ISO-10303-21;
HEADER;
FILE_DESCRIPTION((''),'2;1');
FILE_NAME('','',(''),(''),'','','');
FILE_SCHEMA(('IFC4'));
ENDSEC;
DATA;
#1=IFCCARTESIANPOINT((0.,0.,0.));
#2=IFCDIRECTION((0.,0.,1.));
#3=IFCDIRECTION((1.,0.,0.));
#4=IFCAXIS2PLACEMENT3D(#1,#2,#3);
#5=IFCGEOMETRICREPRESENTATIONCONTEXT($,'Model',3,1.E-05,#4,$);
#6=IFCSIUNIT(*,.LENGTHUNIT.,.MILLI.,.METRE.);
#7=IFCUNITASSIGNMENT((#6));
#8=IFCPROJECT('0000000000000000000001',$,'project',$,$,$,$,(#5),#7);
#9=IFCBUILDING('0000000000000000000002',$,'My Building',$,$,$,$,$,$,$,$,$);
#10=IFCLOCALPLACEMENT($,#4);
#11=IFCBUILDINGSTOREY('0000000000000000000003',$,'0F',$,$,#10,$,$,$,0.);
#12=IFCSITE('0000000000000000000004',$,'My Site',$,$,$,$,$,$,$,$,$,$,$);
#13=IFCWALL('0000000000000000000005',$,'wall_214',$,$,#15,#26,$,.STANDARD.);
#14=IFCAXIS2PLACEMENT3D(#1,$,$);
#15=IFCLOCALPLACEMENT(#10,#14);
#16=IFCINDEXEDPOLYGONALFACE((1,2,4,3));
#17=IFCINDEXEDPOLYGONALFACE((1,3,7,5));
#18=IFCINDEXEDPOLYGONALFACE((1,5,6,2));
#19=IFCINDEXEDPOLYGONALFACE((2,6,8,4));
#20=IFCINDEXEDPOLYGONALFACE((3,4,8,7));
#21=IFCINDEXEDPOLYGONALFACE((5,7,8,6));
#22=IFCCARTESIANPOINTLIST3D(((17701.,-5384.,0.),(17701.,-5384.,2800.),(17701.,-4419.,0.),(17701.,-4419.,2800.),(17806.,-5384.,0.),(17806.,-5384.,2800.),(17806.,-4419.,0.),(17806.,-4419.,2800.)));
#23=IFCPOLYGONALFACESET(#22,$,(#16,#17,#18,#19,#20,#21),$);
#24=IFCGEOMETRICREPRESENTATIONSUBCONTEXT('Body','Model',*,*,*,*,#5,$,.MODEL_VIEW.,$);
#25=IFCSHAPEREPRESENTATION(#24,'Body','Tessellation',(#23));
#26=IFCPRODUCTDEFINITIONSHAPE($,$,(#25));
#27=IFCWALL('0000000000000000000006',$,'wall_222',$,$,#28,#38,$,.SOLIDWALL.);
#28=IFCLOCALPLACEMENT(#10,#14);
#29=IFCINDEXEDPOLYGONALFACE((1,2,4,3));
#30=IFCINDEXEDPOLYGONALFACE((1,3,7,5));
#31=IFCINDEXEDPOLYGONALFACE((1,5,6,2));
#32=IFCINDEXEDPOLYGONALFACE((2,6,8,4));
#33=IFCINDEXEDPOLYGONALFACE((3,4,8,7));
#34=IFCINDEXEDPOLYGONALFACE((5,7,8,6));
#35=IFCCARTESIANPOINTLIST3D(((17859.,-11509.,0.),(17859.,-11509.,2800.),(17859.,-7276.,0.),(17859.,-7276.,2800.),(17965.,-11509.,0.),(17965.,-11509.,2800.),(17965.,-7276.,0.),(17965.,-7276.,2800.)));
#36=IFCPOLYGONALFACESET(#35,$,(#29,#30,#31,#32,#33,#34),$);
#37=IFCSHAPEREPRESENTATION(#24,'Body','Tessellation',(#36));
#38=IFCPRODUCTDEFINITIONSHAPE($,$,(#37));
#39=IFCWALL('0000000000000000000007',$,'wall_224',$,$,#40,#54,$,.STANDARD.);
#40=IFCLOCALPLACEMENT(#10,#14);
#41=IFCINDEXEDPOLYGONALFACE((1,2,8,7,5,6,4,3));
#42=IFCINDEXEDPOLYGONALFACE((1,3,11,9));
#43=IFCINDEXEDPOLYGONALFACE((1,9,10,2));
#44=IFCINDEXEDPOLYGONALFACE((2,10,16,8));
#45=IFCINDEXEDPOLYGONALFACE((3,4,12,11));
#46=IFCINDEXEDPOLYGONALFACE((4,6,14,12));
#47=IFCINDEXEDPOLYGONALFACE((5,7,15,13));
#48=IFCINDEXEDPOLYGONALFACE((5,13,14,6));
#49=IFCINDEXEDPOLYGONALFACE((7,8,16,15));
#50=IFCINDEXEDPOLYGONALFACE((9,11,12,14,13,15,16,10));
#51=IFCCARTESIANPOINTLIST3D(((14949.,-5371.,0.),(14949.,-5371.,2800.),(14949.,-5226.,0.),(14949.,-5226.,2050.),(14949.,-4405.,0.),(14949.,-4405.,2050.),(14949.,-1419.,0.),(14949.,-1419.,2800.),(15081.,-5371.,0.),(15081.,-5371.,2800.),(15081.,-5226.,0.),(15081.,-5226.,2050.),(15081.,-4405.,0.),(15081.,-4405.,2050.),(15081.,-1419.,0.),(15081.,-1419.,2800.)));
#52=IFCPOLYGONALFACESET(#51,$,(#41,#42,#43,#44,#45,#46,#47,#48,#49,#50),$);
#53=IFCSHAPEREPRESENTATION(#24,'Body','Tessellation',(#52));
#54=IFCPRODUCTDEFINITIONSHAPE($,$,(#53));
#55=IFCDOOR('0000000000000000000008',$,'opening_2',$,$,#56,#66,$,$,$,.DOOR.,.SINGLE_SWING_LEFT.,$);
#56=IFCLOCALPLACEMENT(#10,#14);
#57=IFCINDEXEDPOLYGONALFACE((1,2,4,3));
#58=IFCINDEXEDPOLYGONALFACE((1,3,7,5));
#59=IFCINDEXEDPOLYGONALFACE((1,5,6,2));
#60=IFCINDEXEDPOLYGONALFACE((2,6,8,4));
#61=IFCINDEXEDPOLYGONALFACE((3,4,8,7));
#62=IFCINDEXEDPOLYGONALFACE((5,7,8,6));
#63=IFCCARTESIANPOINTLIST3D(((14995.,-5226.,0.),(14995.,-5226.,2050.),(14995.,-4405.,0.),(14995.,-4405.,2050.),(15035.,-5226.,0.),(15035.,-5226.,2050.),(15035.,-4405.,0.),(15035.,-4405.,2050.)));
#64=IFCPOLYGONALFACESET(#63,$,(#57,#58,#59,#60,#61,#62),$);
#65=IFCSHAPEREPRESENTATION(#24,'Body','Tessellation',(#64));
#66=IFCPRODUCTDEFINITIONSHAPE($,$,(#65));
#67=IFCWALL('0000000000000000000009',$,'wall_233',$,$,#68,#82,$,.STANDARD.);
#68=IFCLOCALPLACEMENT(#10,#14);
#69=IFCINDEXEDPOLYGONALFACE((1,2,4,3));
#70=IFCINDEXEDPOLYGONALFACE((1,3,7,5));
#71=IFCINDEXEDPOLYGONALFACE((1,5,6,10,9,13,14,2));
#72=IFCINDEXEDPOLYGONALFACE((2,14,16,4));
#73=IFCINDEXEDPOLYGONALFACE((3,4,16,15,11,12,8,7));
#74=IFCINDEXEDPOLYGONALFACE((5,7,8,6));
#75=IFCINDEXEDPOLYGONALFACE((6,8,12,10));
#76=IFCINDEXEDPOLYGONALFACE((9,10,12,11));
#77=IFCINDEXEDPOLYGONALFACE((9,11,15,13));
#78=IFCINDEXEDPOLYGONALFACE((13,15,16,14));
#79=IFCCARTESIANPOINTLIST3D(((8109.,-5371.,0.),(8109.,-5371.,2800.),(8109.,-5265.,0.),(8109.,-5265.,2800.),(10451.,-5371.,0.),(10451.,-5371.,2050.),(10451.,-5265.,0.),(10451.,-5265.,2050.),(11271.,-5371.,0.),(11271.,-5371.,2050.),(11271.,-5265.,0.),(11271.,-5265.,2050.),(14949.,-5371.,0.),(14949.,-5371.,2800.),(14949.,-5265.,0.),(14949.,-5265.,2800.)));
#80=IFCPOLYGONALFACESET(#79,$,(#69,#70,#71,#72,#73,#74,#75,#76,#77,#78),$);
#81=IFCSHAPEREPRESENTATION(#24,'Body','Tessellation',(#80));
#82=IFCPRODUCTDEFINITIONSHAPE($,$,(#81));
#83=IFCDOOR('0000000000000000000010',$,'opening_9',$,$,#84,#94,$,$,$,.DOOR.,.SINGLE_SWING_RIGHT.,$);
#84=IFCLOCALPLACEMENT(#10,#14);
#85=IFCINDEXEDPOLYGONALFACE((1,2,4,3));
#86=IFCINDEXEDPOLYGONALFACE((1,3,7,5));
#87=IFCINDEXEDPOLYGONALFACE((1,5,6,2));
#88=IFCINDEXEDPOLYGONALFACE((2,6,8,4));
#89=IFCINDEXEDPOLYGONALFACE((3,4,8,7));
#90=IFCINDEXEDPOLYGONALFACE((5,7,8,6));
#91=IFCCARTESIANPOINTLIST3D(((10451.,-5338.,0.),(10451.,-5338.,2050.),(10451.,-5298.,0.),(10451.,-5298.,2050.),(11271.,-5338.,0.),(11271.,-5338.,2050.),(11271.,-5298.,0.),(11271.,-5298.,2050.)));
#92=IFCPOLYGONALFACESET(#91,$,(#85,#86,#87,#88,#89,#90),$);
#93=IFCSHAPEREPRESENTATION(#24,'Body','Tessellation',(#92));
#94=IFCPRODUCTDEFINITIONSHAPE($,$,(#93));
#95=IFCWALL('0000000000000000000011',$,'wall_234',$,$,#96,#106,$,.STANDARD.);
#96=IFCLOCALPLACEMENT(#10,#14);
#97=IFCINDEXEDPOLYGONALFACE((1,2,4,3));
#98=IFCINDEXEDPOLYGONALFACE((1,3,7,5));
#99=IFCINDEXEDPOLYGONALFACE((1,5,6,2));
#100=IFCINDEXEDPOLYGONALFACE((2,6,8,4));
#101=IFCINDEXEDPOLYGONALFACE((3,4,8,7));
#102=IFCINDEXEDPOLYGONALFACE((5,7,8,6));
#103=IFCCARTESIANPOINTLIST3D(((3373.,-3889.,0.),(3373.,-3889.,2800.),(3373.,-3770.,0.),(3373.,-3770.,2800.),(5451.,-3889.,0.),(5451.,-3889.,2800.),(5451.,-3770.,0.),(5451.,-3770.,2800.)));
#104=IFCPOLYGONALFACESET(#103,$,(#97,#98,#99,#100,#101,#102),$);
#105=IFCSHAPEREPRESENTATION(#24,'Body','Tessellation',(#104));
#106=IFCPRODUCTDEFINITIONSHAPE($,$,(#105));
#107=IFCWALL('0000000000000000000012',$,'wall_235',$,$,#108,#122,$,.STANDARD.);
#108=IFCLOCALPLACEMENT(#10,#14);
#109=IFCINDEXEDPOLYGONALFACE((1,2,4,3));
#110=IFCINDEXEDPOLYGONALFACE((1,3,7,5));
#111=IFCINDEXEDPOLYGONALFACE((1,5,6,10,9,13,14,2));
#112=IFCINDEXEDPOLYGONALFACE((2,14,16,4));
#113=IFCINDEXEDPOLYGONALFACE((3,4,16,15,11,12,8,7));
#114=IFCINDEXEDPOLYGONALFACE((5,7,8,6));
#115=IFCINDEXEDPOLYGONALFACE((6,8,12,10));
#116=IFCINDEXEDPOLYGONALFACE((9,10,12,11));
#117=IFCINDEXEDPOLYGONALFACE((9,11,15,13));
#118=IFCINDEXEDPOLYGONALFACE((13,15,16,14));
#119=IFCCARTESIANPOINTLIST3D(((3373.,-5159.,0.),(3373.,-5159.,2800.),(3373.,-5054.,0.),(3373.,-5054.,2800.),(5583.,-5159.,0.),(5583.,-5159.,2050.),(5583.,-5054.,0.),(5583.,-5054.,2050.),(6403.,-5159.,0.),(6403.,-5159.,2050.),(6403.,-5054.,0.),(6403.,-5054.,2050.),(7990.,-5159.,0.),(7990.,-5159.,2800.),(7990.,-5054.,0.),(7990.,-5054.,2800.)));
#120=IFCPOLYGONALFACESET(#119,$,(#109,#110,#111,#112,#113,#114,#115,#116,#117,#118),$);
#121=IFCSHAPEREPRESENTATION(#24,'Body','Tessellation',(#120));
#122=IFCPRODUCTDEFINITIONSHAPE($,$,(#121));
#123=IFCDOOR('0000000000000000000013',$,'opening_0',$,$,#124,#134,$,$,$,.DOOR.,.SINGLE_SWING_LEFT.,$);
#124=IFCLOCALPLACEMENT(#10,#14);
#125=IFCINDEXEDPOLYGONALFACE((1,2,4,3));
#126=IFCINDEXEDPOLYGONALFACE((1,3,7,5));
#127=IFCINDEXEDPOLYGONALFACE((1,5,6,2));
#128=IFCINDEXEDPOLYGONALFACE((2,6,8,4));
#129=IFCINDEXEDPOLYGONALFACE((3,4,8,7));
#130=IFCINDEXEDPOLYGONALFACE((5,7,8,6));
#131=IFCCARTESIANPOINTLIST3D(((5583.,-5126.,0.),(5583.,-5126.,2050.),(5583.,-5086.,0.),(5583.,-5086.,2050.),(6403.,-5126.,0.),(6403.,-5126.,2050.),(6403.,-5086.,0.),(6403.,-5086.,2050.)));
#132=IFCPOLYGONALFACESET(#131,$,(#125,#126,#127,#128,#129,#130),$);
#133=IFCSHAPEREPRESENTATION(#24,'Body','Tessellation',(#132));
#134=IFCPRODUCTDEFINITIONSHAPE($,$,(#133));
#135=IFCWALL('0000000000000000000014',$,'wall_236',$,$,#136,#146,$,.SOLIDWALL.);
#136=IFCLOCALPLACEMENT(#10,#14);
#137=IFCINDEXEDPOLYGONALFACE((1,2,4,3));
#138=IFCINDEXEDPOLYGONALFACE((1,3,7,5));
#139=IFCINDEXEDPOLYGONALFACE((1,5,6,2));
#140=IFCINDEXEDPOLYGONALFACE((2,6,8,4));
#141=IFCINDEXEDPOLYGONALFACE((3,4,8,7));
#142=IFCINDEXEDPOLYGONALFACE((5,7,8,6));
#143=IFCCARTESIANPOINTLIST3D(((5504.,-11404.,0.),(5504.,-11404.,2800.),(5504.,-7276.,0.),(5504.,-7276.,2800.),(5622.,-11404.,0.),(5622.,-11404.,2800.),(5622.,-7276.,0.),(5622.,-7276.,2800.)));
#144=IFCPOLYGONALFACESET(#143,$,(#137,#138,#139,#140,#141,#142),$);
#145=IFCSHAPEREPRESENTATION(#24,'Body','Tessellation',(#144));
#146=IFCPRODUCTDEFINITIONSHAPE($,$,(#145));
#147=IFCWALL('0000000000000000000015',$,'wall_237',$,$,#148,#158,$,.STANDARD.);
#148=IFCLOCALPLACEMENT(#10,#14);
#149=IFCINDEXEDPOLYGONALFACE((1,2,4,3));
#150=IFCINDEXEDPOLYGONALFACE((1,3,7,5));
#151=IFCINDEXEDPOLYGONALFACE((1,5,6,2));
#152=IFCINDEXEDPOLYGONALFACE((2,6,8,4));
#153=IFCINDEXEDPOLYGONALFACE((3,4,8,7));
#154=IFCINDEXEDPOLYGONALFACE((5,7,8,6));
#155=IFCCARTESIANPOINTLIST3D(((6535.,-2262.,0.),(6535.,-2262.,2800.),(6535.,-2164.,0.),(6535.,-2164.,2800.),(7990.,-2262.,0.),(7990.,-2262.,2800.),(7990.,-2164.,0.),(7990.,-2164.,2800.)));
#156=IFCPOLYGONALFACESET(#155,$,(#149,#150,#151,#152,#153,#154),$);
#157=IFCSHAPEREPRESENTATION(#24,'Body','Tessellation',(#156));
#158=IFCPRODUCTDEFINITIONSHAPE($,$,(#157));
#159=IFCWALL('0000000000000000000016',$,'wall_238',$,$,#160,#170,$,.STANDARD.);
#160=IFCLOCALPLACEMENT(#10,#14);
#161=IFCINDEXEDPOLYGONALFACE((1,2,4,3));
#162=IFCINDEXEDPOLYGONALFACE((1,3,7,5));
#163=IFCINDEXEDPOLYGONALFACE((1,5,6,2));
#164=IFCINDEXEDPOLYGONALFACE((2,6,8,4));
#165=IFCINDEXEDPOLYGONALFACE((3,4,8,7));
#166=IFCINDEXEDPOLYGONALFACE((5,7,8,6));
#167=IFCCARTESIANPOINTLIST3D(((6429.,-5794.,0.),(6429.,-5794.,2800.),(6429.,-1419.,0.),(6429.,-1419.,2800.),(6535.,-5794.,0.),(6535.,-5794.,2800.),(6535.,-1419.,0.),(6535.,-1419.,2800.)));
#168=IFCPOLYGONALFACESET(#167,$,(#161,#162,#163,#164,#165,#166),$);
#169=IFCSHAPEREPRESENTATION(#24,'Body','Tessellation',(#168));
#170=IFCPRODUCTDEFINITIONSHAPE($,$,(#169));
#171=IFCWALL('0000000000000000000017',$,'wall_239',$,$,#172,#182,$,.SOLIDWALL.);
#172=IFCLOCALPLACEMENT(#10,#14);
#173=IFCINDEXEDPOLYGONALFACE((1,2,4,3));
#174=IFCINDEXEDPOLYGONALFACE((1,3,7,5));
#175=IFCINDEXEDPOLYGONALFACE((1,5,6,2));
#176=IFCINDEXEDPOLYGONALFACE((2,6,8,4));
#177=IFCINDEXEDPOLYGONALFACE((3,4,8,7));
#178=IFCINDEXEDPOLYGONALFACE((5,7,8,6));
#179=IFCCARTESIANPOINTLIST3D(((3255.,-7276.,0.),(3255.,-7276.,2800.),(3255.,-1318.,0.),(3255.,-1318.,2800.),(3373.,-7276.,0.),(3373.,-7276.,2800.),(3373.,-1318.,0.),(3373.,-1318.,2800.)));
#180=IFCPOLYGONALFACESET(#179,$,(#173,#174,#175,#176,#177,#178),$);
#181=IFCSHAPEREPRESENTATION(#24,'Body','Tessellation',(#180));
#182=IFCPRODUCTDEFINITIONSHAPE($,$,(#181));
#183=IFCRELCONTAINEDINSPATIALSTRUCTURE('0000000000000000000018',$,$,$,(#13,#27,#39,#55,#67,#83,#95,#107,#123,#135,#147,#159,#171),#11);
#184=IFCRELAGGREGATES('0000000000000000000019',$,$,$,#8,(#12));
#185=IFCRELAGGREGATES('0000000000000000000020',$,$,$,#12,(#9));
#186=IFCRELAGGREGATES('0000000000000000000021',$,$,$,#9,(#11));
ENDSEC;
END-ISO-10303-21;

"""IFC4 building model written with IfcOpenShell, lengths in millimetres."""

from ifc_helpers import new_model, si_unit, origin_with_axes, place, context, subcontext, project, spatial, indexed_curve, outline, extrude, element, fill, save


model = new_model("IFC4")

# Units and contexts
model_context = context("Model", 3, precision=1e-05, world=origin_with_axes())
body_context = subcontext(model_context, "Body", "Model", "MODEL_VIEW")
ifc_project = project(units=[si_unit("LENGTHUNIT", "METRE", prefix="MILLI")], contexts=[model_context])

# Site, building, storey
site = spatial("IfcSite", under=ifc_project, Name="My Site")
building = spatial("IfcBuilding", under=site, Name="My Building")
storey_placement = place(None, origin_with_axes())
storey = spatial("IfcBuildingStorey", under=building, at=storey_placement, Name="0F", Elevation=0.0)

# Walls
wall_1_placement = place(storey_placement, origin_with_axes())
element("IfcWall", 1, at=wall_1_placement, inside=storey, Name="wall_214", PredefinedType="STANDARD", context=body_context, shape_type="SweptSolid", body=[
    extrude(outline(indexed_curve([(17701.0, -4419.0), (17701.0, -5384.0), (17806.0, -5384.0), (17806.0, -4419.0), (17701.0, -4419.0)])), None, (0.0, 0.0, 1.0), 2800.0),
])
wall_2_placement = place(storey_placement, origin_with_axes())
element("IfcWall", 2, at=wall_2_placement, inside=storey, Name="wall_222", PredefinedType="SOLIDWALL", context=body_context, shape_type="SweptSolid", body=[
    extrude(outline(indexed_curve([(17859.0, -7276.0), (17859.0, -11509.0), (17965.0, -11509.0), (17965.0, -7276.0), (17859.0, -7276.0)])), None, (0.0, 0.0, 1.0), 2800.0),
])

# Walls, openings, doors
wall_3_placement = place(storey_placement, origin_with_axes())
wall_3 = element("IfcWall", 3, at=wall_3_placement, inside=storey, Name="wall_224", PredefinedType="STANDARD", context=body_context, shape_type="SweptSolid", body=[
    extrude(outline(indexed_curve([(14949.0, -1419.0), (14949.0, -5371.0), (15081.0, -5371.0), (15081.0, -1419.0), (14949.0, -1419.0)])), None, (0.0, 0.0, 1.0), 2800.0),
])
opening_1_placement = place(wall_3_placement, origin_with_axes())
opening_1 = element("IfcOpeningElement", 4, at=opening_1_placement, cuts=wall_3, ObjectType="Opening", context=body_context, shape_type="SweptSolid", body=[
    extrude(outline(indexed_curve([(14883.0, -5226.0), (15147.0, -5226.0), (15147.0, -4405.0), (14883.0, -4405.0), (14883.0, -5226.0)])), None, (0.0, 0.0, 1.0), 2050.0),
])
door_1_placement = place(opening_1_placement, origin_with_axes())
door_1 = element("IfcDoor", 5, at=door_1_placement, inside=storey, Name="opening_2", OperationType="SINGLE_SWING_LEFT", PredefinedType="DOOR", context=body_context, shape_type="SweptSolid", body=[
    extrude(outline(indexed_curve([(14995.0, -5226.0), (15035.0, -5226.0), (15035.0, -4405.0), (14995.0, -4405.0), (14995.0, -5226.0)])), None, (0.0, 0.0, 1.0), 2050.0),
])
fill(opening_1, door_1)
wall_4_placement = place(storey_placement, origin_with_axes())
wall_4 = element("IfcWall", 6, at=wall_4_placement, inside=storey, Name="wall_233", PredefinedType="STANDARD", context=body_context, shape_type="SweptSolid", body=[
    extrude(outline(indexed_curve([(8109.0, -5371.0), (14949.0, -5371.0), (14949.0, -5265.0), (8109.0, -5265.0), (8109.0, -5371.0)])), None, (0.0, 0.0, 1.0), 2800.0),
])
opening_2_placement = place(wall_4_placement, origin_with_axes())
opening_2 = element("IfcOpeningElement", 7, at=opening_2_placement, cuts=wall_4, ObjectType="Opening", context=body_context, shape_type="SweptSolid", body=[
    extrude(outline(indexed_curve([(11271.0, -5437.0), (11271.0, -5198.0), (10451.0, -5198.0), (10451.0, -5437.0), (11271.0, -5437.0)])), None, (0.0, 0.0, 1.0), 2050.0),
])
door_2_placement = place(opening_2_placement, origin_with_axes())
door_2 = element("IfcDoor", 8, at=door_2_placement, inside=storey, Name="opening_9", OperationType="SINGLE_SWING_RIGHT", PredefinedType="DOOR", context=body_context, shape_type="SweptSolid", body=[
    extrude(outline(indexed_curve([(11271.0, -5338.0), (11271.0, -5298.0), (10451.0, -5298.0), (10451.0, -5338.0), (11271.0, -5338.0)])), None, (0.0, 0.0, 1.0), 2050.0),
])
fill(opening_2, door_2)

# Wall
wall_5_placement = place(storey_placement, origin_with_axes())
element("IfcWall", 9, at=wall_5_placement, inside=storey, Name="wall_234", PredefinedType="STANDARD", context=body_context, shape_type="SweptSolid", body=[
    extrude(outline(indexed_curve([(3373.0, -3889.0), (5451.0, -3889.0), (5451.0, -3770.0), (3373.0, -3770.0), (3373.0, -3889.0)])), None, (0.0, 0.0, 1.0), 2800.0),
])

# Wall, opening, door
wall_6_placement = place(storey_placement, origin_with_axes())
wall_6 = element("IfcWall", 10, at=wall_6_placement, inside=storey, Name="wall_235", PredefinedType="STANDARD", context=body_context, shape_type="SweptSolid", body=[
    extrude(outline(indexed_curve([(3373.0, -5159.0), (7990.0, -5159.0), (7990.0, -5054.0), (3373.0, -5054.0), (3373.0, -5159.0)])), None, (0.0, 0.0, 1.0), 2800.0),
])
opening_3_placement = place(wall_6_placement, origin_with_axes())
opening_3 = element("IfcOpeningElement", 11, at=opening_3_placement, cuts=wall_6, ObjectType="Opening", context=body_context, shape_type="SweptSolid", body=[
    extrude(outline(indexed_curve([(6403.0, -5225.0), (6403.0, -4988.0), (5583.0, -4988.0), (5583.0, -5225.0), (6403.0, -5225.0)])), None, (0.0, 0.0, 1.0), 2050.0),
])
door_3_placement = place(opening_3_placement, origin_with_axes())
door_3 = element("IfcDoor", 12, at=door_3_placement, inside=storey, Name="opening_0", OperationType="SINGLE_SWING_LEFT", PredefinedType="DOOR", context=body_context, shape_type="SweptSolid", body=[
    extrude(outline(indexed_curve([(6403.0, -5126.0), (6403.0, -5086.0), (5583.0, -5086.0), (5583.0, -5126.0), (6403.0, -5126.0)])), None, (0.0, 0.0, 1.0), 2050.0),
])
fill(opening_3, door_3)

# Walls
wall_7_placement = place(storey_placement, origin_with_axes())
element("IfcWall", 13, at=wall_7_placement, inside=storey, Name="wall_236", PredefinedType="SOLIDWALL", context=body_context, shape_type="SweptSolid", body=[
    extrude(outline(indexed_curve([(5504.0, -7276.0), (5504.0, -11404.0), (5622.0, -11404.0), (5622.0, -7276.0), (5504.0, -7276.0)])), None, (0.0, 0.0, 1.0), 2800.0),
])
wall_8_placement = place(storey_placement, origin_with_axes())
element("IfcWall", 14, at=wall_8_placement, inside=storey, Name="wall_237", PredefinedType="STANDARD", context=body_context, shape_type="SweptSolid", body=[
    extrude(outline(indexed_curve([(6535.0, -2262.0), (7990.0, -2262.0), (7990.0, -2164.0), (6535.0, -2164.0), (6535.0, -2262.0)])), None, (0.0, 0.0, 1.0), 2800.0),
])
wall_9_placement = place(storey_placement, origin_with_axes())
element("IfcWall", 15, at=wall_9_placement, inside=storey, Name="wall_238", PredefinedType="STANDARD", context=body_context, shape_type="SweptSolid", body=[
    extrude(outline(indexed_curve([(6429.0, -1419.0), (6429.0, -5794.0), (6535.0, -5794.0), (6535.0, -1419.0), (6429.0, -1419.0)])), None, (0.0, 0.0, 1.0), 2800.0),
])
wall_10_placement = place(storey_placement, origin_with_axes())
element("IfcWall", 16, at=wall_10_placement, inside=storey, Name="wall_239", PredefinedType="SOLIDWALL", context=body_context, shape_type="SweptSolid", body=[
    extrude(outline(indexed_curve([(3255.0, -1318.0), (3255.0, -7276.0), (3373.0, -7276.0), (3373.0, -1318.0), (3255.0, -1318.0)])), None, (0.0, 0.0, 1.0), 2800.0),
])

save(model, "model.ifc")
